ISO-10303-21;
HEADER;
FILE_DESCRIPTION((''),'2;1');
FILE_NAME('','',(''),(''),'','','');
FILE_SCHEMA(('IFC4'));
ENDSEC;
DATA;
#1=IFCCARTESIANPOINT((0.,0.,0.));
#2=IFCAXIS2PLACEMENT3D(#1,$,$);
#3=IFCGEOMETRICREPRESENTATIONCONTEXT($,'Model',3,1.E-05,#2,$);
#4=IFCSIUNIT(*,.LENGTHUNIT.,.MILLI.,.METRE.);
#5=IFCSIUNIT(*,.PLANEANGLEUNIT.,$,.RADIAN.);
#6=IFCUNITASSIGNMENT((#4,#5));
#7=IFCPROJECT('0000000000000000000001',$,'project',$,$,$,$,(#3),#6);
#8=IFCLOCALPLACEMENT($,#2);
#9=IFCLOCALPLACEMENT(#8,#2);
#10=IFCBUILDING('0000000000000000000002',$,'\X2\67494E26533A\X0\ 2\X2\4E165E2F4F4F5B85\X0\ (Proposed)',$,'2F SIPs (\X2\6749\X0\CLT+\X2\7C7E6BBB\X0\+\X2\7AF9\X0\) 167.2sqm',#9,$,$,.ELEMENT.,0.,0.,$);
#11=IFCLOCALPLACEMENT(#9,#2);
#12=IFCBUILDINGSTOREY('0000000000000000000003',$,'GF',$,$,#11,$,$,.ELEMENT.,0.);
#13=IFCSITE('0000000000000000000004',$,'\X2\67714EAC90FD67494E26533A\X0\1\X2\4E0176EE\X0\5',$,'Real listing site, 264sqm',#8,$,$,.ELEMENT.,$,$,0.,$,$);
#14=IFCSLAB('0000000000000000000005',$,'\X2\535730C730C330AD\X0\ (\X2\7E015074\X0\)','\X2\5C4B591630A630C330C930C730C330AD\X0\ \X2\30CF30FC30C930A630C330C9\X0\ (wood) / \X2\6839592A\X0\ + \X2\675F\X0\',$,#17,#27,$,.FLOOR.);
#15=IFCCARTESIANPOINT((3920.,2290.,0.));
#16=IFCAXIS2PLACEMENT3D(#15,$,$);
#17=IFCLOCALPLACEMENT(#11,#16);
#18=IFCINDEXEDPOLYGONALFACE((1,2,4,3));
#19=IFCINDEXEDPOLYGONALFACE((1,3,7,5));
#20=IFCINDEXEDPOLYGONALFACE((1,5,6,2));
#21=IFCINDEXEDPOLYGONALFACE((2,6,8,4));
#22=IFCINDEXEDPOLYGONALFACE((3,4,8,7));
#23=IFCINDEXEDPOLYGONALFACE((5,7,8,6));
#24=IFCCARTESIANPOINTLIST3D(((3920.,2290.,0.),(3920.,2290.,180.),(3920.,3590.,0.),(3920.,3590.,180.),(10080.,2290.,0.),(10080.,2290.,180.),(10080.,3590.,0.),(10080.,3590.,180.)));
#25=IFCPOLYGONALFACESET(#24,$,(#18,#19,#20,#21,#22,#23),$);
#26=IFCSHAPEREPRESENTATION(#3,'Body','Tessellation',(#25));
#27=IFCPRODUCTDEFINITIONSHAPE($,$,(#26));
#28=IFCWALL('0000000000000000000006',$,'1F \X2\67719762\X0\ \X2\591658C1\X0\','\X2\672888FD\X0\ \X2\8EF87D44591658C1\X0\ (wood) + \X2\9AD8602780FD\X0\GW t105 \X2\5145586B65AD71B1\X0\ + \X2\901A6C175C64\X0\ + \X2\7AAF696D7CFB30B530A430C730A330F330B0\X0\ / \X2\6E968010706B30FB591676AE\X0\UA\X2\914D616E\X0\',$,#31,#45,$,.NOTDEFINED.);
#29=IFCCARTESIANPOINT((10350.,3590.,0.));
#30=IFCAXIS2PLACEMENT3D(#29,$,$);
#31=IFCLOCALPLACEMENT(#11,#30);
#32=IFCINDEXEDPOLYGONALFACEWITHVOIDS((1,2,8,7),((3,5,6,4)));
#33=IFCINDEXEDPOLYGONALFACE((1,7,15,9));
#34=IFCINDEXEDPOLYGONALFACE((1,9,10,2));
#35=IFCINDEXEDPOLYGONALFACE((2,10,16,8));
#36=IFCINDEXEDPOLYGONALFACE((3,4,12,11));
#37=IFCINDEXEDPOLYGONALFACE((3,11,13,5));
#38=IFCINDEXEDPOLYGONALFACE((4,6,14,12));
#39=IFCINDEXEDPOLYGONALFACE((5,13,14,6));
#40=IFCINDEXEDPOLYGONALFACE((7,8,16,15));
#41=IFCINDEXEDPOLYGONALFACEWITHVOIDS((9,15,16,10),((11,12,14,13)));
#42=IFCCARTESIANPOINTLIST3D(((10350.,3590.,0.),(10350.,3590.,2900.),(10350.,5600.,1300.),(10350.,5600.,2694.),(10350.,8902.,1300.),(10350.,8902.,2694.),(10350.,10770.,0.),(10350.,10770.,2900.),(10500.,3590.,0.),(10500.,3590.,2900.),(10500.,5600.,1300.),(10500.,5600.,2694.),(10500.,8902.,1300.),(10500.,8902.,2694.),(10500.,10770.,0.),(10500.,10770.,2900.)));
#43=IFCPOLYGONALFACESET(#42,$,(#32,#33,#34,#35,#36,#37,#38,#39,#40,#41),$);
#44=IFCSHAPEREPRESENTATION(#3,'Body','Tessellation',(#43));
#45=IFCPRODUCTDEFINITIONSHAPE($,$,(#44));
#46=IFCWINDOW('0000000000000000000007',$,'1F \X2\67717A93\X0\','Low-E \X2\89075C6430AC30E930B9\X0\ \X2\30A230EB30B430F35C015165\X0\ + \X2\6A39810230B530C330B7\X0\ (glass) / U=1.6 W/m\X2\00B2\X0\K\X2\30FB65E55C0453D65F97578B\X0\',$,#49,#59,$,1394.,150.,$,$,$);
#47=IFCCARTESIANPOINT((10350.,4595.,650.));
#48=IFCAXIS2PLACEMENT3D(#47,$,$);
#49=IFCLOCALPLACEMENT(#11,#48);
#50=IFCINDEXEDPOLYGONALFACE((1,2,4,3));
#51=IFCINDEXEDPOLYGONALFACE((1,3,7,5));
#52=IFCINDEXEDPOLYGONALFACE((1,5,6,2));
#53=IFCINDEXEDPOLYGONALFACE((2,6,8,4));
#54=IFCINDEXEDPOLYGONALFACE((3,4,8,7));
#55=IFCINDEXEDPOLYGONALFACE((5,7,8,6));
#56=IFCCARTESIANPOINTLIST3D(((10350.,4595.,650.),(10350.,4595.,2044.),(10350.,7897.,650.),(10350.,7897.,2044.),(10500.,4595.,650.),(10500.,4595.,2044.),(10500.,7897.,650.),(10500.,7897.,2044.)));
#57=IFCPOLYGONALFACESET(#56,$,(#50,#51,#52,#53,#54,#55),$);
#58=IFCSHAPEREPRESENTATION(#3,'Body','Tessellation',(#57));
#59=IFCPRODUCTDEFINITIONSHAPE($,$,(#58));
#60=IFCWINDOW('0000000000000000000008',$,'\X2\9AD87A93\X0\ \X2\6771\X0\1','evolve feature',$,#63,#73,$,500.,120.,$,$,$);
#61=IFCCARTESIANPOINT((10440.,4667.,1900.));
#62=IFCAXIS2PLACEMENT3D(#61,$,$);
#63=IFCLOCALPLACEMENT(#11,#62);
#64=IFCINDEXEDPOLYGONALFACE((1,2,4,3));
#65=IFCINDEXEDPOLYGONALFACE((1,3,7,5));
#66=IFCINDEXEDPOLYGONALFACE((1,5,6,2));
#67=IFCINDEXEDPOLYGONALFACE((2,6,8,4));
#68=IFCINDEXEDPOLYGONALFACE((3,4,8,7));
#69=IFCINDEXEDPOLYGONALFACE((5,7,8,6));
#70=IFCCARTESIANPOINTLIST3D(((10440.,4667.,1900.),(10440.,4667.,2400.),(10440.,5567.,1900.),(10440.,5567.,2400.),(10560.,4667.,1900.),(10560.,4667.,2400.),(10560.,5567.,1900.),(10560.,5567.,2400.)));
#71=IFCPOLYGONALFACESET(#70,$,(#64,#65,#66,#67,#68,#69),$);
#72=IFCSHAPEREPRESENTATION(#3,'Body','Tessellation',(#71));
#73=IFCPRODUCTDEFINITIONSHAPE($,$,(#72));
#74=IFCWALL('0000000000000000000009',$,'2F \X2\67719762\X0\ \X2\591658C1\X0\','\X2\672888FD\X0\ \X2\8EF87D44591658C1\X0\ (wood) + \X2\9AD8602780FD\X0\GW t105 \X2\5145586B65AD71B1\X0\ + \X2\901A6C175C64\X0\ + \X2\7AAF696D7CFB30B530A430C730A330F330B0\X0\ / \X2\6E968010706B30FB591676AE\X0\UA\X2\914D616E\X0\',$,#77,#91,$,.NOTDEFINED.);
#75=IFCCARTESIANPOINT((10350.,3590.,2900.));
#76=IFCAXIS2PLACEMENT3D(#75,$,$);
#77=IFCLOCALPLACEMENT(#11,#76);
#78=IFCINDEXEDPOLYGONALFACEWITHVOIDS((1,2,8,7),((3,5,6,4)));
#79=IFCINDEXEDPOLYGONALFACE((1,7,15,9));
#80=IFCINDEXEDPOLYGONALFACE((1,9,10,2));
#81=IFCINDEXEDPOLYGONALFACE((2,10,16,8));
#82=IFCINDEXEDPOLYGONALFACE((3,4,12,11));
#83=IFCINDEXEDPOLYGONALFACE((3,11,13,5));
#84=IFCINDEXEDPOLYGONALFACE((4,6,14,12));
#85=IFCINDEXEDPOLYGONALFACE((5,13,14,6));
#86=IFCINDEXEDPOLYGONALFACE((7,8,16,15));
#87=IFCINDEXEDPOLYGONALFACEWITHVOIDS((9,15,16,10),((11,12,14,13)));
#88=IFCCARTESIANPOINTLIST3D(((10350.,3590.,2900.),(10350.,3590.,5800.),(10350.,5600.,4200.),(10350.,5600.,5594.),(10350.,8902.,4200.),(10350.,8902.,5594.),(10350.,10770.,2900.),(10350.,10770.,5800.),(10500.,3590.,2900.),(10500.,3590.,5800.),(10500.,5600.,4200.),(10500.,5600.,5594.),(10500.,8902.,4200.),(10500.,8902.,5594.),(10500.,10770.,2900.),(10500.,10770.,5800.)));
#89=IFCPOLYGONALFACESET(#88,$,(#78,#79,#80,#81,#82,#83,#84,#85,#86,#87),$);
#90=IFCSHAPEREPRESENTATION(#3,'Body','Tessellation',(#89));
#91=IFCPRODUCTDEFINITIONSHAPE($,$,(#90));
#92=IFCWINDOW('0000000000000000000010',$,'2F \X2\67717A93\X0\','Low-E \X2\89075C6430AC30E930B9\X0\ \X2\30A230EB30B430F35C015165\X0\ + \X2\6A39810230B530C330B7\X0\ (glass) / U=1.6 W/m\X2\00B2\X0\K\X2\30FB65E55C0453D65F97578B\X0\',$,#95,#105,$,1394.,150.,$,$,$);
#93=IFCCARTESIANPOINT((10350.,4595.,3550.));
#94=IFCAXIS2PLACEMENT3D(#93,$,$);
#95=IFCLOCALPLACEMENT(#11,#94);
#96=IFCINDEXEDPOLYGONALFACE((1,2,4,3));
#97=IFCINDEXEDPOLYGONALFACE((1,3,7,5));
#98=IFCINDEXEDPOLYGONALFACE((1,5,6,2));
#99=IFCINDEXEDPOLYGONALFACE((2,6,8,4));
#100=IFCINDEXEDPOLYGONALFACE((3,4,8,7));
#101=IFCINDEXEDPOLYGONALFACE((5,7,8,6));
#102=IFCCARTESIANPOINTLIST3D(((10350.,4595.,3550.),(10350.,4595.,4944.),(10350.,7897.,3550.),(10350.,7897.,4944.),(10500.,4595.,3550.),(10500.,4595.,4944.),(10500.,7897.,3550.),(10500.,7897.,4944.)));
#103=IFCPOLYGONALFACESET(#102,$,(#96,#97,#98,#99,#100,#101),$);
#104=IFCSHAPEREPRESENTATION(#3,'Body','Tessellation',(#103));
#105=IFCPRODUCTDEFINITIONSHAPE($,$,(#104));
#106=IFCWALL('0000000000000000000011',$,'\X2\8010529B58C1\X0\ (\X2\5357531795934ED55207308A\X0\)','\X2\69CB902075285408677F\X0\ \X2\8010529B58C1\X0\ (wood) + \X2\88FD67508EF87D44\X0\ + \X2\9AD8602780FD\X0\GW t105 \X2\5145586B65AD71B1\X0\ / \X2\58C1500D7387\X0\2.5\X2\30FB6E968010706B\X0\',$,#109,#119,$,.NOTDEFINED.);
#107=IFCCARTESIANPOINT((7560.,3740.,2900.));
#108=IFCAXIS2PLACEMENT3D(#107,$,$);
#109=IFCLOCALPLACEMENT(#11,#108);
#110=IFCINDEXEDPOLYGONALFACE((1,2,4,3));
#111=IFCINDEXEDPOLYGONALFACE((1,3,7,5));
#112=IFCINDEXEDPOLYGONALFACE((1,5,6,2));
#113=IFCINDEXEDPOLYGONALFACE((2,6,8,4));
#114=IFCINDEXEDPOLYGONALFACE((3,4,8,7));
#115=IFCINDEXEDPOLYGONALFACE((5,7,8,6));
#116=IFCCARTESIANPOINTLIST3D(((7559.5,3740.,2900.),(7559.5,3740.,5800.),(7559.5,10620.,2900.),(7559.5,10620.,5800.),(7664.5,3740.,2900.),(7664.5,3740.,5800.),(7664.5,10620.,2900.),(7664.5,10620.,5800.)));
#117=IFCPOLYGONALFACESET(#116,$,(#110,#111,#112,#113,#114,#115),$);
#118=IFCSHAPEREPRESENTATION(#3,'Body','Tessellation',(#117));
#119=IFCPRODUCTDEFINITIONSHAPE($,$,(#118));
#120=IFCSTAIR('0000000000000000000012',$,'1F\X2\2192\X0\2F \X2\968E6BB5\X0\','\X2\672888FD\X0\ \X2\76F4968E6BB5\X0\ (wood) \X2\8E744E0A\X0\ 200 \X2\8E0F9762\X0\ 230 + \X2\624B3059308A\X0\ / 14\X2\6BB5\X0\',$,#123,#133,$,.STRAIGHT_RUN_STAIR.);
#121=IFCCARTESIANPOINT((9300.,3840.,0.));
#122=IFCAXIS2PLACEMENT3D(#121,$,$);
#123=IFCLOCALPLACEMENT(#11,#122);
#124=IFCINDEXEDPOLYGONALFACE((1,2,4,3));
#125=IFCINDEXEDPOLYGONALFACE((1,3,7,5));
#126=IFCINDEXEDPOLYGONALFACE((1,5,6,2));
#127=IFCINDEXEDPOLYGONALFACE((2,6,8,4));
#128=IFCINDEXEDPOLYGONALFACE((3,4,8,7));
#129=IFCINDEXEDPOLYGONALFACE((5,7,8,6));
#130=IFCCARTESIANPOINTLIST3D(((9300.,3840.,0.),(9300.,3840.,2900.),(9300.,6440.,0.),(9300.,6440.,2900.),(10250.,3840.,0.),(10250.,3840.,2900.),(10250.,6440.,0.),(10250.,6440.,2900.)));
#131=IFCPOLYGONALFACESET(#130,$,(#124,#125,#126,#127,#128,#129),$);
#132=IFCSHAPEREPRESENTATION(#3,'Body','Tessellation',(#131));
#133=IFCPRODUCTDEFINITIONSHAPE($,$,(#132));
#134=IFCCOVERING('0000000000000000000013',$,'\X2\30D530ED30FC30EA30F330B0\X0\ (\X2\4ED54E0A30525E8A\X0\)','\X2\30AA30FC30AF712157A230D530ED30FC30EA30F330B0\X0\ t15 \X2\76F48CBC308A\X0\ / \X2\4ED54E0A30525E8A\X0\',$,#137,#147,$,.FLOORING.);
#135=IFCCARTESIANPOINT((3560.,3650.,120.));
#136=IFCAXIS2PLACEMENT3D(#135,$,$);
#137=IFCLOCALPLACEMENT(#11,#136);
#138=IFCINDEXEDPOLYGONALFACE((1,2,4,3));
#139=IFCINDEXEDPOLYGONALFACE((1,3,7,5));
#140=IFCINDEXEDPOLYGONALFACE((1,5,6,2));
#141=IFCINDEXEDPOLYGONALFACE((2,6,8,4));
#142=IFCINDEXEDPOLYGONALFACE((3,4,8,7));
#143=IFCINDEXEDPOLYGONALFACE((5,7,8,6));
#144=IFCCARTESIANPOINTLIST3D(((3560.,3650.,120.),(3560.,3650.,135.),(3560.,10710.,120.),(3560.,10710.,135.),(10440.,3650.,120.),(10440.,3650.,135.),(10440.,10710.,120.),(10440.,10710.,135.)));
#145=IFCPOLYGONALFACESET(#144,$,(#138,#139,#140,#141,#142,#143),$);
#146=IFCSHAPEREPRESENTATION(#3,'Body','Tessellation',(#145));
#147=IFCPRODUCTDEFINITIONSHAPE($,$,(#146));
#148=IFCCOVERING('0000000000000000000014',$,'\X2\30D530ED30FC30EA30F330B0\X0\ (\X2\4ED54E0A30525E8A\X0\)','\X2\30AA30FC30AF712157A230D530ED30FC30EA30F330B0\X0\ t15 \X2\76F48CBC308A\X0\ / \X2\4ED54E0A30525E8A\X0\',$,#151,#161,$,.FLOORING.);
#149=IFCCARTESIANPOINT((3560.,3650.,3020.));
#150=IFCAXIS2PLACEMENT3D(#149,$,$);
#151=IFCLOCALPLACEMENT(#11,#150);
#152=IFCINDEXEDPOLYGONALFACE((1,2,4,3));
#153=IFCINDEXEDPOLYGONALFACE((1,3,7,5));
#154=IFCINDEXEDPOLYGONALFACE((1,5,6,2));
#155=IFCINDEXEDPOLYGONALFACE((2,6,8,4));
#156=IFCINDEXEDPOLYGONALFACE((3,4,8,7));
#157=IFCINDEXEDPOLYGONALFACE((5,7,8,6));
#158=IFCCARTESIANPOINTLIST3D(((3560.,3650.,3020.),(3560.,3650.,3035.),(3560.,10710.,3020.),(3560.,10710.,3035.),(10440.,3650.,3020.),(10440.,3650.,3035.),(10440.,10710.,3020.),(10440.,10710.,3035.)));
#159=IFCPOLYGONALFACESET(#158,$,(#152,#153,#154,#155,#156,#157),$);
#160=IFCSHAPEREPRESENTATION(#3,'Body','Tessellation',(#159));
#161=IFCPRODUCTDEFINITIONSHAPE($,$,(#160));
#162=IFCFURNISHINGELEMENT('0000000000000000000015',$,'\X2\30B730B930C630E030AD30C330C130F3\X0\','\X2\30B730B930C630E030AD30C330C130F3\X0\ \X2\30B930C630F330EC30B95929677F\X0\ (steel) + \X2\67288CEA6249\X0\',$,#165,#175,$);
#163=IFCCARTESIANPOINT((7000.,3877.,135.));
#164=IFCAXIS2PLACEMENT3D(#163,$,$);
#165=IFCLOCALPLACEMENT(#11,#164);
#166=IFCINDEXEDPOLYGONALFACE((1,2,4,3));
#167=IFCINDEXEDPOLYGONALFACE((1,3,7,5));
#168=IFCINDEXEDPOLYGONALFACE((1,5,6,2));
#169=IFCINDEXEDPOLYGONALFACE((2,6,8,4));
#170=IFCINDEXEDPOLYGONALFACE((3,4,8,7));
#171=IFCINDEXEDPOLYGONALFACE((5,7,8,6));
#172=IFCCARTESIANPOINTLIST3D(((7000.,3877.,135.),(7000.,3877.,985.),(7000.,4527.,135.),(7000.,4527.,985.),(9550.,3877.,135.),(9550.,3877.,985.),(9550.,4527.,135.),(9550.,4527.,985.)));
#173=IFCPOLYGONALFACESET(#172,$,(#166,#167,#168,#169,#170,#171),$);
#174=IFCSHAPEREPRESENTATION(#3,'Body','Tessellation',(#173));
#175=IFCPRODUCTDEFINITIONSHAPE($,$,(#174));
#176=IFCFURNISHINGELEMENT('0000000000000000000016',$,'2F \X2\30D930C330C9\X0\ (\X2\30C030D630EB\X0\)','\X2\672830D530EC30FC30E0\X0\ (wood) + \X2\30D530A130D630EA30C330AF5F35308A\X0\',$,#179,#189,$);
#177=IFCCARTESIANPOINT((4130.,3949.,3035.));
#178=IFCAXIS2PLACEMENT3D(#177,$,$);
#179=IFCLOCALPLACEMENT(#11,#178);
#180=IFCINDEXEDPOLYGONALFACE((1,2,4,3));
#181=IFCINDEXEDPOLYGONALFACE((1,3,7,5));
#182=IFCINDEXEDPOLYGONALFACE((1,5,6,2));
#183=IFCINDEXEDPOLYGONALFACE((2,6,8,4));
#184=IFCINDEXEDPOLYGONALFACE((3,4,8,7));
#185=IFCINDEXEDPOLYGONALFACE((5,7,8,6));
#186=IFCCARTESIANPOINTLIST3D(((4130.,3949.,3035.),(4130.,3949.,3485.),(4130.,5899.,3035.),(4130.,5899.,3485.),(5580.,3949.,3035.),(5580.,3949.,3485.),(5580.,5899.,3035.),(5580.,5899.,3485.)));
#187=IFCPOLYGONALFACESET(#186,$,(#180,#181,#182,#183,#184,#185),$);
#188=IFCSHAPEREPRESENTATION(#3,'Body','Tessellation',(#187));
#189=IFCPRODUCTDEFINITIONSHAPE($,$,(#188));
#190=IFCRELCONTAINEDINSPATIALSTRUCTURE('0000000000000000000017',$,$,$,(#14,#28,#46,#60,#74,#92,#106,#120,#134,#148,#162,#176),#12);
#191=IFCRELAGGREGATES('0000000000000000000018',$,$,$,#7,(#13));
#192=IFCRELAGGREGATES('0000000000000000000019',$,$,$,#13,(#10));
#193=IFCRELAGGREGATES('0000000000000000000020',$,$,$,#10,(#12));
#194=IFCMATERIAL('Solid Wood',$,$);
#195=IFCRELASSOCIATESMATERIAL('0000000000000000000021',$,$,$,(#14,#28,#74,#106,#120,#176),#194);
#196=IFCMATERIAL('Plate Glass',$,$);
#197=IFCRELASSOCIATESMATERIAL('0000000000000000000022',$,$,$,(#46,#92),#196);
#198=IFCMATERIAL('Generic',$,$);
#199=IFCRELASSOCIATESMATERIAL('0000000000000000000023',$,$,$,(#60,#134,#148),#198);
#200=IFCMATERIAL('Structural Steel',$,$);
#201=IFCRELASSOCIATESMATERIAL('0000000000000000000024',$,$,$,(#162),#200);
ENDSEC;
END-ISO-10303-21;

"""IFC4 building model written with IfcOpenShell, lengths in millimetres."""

from ifc_helpers import new_model, si_unit, frame, frame_2d, origin, place, context, project, spatial, rectangle, extrude, material, element, fill, save


model = new_model("IFC4")

# Units and contexts
model_context = context("Model", 3, precision=1e-05, world=origin())
ifc_project = project(units=[si_unit("LENGTHUNIT", "METRE", prefix="MILLI"), si_unit("PLANEANGLEUNIT", "RADIAN")], contexts=[model_context])

# Site, building, storey
site_placement = place(None, origin())
site = spatial("IfcSite", under=ifc_project, at=site_placement, Name="東京都杉並区1丁目5", ObjectType="Real listing site, 264sqm", CompositionType="ELEMENT", RefElevation=0.0)
building_placement = place(site_placement, origin())
building = spatial("IfcBuilding", under=site, at=building_placement, Name="杉並区 2世帯住宅 (Proposed)", ObjectType="2F SIPs (杉CLT+籾殻+竹) 167.2sqm", CompositionType="ELEMENT", ElevationOfRefHeight=0.0, ElevationOfTerrain=0.0)
storey_placement = place(building_placement, origin())
storey = spatial("IfcBuildingStorey", under=building, at=storey_placement, Name="GF", CompositionType="ELEMENT", Elevation=0.0)

# Slab
ifc_material_1 = material(Name="Solid Wood")
slab_placement = place(storey_placement, frame((3920.0, 2290.0, 0.0)))
element("IfcSlab", 1, at=slab_placement, inside=storey, material=ifc_material_1, Name="南デッキ (縁側)", Description="屋外ウッドデッキ ハードウッド (wood) / 根太 + 束", PredefinedType="FLOOR", context=model_context, shape_type="SweptSolid", body=[
    extrude(rectangle(XDim=6160.0, YDim=1300.0, at=frame_2d((3080.0, 650.0))), frame((3920.0, 2290.0, 0.0)), (0.0, 0.0, 1.0), 180.0),
])

# Wall, openings, windows
wall_1_placement = place(storey_placement, frame((10350.0, 3590.0, 0.0)))
wall_1 = element("IfcWall", 2, at=wall_1_placement, inside=storey, material=ifc_material_1, Name="1F 東面 外壁", Description="木製 軸組外壁 (wood) + 高性能GW t105 充填断熱 + 通気層 + 窯業系サイディング / 準耐火・外皮UA配慮", PredefinedType="NOTDEFINED", context=model_context, shape_type="SweptSolid", body=[
    extrude(rectangle(XDim=150.0, YDim=7180.0, at=frame_2d((75.0, 3590.0))), frame((10350.0, 3590.0, 0.0)), (0.0, 0.0, 1.0), 2900.0),
])
opening_1_placement = place(storey_placement, frame((10350.0, 4595.0, 650.0)))
opening_1 = element("IfcOpeningElement", 3, at=opening_1_placement, cuts=wall_1, PredefinedType="NOTDEFINED", context=model_context, shape_type="SweptSolid", body=[
    extrude(rectangle(XDim=150.0, YDim=3302.0, at=frame_2d((75.0, 1651.0))), frame((10350.0, 4595.0, 650.0)), (0.0, 0.0, 1.0), 1394.0),
])
opening_2_placement = place(storey_placement, frame((10440.0, 4667.0, 1900.0)))
opening_2 = element("IfcOpeningElement", 4, at=opening_2_placement, cuts=wall_1, PredefinedType="NOTDEFINED", context=model_context, shape_type="SweptSolid", body=[
    extrude(rectangle(XDim=120.0, YDim=900.0, at=frame_2d((60.0, 450.0))), frame((10440.0, 4667.0, 1900.0)), (0.0, 0.0, 1.0), 500.0),
])
ifc_material_2 = material(Name="Plate Glass")
window_1_placement = place(storey_placement, frame((10350.0, 4595.0, 650.0)))
window_1 = element("IfcWindow", 5, at=window_1_placement, inside=storey, material=ifc_material_2, Name="1F 東窓", Description="Low-E 複層ガラス アルゴン封入 + 樹脂サッシ (glass) / U=1.6 W/m²K・日射取得型", OverallHeight=1394.0, OverallWidth=150.0, context=model_context, shape_type="SweptSolid", body=[
    extrude(rectangle(XDim=150.0, YDim=3302.0, at=frame_2d((75.0, 1651.0))), frame((10350.0, 4595.0, 650.0)), (0.0, 0.0, 1.0), 1394.0),
])
fill(opening_1, window_1)
ifc_material_3 = material(Name="Generic")
window_2_placement = place(storey_placement, frame((10440.0, 4667.0, 1900.0)))
window_2 = element("IfcWindow", 6, at=window_2_placement, inside=storey, material=ifc_material_3, Name="高窓 東1", Description="evolve feature", OverallHeight=500.0, OverallWidth=120.0, context=model_context, shape_type="SweptSolid", body=[
    extrude(rectangle(XDim=120.0, YDim=900.0, at=frame_2d((60.0, 450.0))), frame((10440.0, 4667.0, 1900.0)), (0.0, 0.0, 1.0), 500.0),
])
fill(opening_2, window_2)

# Wall, opening, window
wall_2_placement = place(storey_placement, frame((10350.0, 3590.0, 2900.0)))
wall_2 = element("IfcWall", 7, at=wall_2_placement, inside=storey, material=ifc_material_1, Name="2F 東面 外壁", Description="木製 軸組外壁 (wood) + 高性能GW t105 充填断熱 + 通気層 + 窯業系サイディング / 準耐火・外皮UA配慮", PredefinedType="NOTDEFINED", context=model_context, shape_type="SweptSolid", body=[
    extrude(rectangle(XDim=150.0, YDim=7180.0, at=frame_2d((75.0, 3590.0))), frame((10350.0, 3590.0, 2900.0)), (0.0, 0.0, 1.0), 2900.0),
])
opening_3_placement = place(storey_placement, frame((10350.0, 4595.0, 3550.0)))
opening_3 = element("IfcOpeningElement", 8, at=opening_3_placement, cuts=wall_2, PredefinedType="NOTDEFINED", context=model_context, shape_type="SweptSolid", body=[
    extrude(rectangle(XDim=150.0, YDim=3302.0, at=frame_2d((75.0, 1651.0))), frame((10350.0, 4595.0, 3550.0)), (0.0, 0.0, 1.0), 1394.0),
])
window_3_placement = place(storey_placement, frame((10350.0, 4595.0, 3550.0)))
window_3 = element("IfcWindow", 9, at=window_3_placement, inside=storey, material=ifc_material_2, Name="2F 東窓", Description="Low-E 複層ガラス アルゴン封入 + 樹脂サッシ (glass) / U=1.6 W/m²K・日射取得型", OverallHeight=1394.0, OverallWidth=150.0, context=model_context, shape_type="SweptSolid", body=[
    extrude(rectangle(XDim=150.0, YDim=3302.0, at=frame_2d((75.0, 1651.0))), frame((10350.0, 4595.0, 3550.0)), (0.0, 0.0, 1.0), 1394.0),
])
fill(opening_3, window_3)

# Wall
wall_3_placement = place(storey_placement, frame((7560.0, 3740.0, 2900.0)))
element("IfcWall", 10, at=wall_3_placement, inside=storey, material=ifc_material_1, Name="耐力壁 (南北間仕切り)", Description="構造用合板 耐力壁 (wood) + 製材軸組 + 高性能GW t105 充填断熱 / 壁倍率2.5・準耐火", PredefinedType="NOTDEFINED", context=model_context, shape_type="SweptSolid", body=[
    extrude(rectangle(XDim=105.0, YDim=6880.0, at=frame_2d((52.0, 3440.0))), frame((7560.0, 3740.0, 2900.0)), (0.0, 0.0, 1.0), 2900.0),
])

# Stair
stair_placement = place(storey_placement, frame((9300.0, 3840.0, 0.0)))
element("IfcStair", 11, at=stair_placement, inside=storey, material=ifc_material_1, Name="1F→2F 階段", Description="木製 直階段 (wood) 蹴上 200 踏面 230 + 手すり / 14段", PredefinedType="STRAIGHT_RUN_STAIR", context=model_context, shape_type="SweptSolid", body=[
    extrude(rectangle(XDim=950.0, YDim=2600.0, at=frame_2d((475.0, 1300.0))), frame((9300.0, 3840.0, 0.0)), (0.0, 0.0, 1.0), 2900.0),
])

# Coverings
covering_1_placement = place(storey_placement, frame((3560.0, 3650.0, 120.0)))
element("IfcCovering", 12, at=covering_1_placement, inside=storey, material=ifc_material_3, Name="フローリング (仕上げ床)", Description="オーク無垢フローリング t15 直貼り / 仕上げ床", PredefinedType="FLOORING", context=model_context, shape_type="SweptSolid", body=[
    extrude(rectangle(XDim=6880.0, YDim=7060.0, at=frame_2d((3440.0, 3530.0))), frame((3560.0, 3650.0, 120.0)), (0.0, 0.0, 1.0), 15.0),
])
covering_2_placement = place(storey_placement, frame((3560.0, 3650.0, 3020.0)))
element("IfcCovering", 13, at=covering_2_placement, inside=storey, material=ifc_material_3, Name="フローリング (仕上げ床)", Description="オーク無垢フローリング t15 直貼り / 仕上げ床", PredefinedType="FLOORING", context=model_context, shape_type="SweptSolid", body=[
    extrude(rectangle(XDim=6880.0, YDim=7060.0, at=frame_2d((3440.0, 3530.0))), frame((3560.0, 3650.0, 3020.0)), (0.0, 0.0, 1.0), 15.0),
])

# Furnishing elements
ifc_material_4 = material(Name="Structural Steel")
furnishing_1_placement = place(storey_placement, frame((7000.0, 3877.0, 135.0)))
element("IfcFurnishingElement", 14, at=furnishing_1_placement, inside=storey, material=ifc_material_4, Name="システムキッチン", Description="システムキッチン ステンレス天板 (steel) + 木質扉", context=model_context, shape_type="SweptSolid", body=[
    extrude(rectangle(XDim=2550.0, YDim=650.0, at=frame_2d((1275.0, 325.0))), frame((7000.0, 3877.0, 135.0)), (0.0, 0.0, 1.0), 850.0),
])
furnishing_2_placement = place(storey_placement, frame((4130.0, 3949.0, 3035.0)))
element("IfcFurnishingElement", 15, at=furnishing_2_placement, inside=storey, material=ifc_material_1, Name="2F ベッド (ダブル)", Description="木フレーム (wood) + ファブリック張り", context=model_context, shape_type="SweptSolid", body=[
    extrude(rectangle(XDim=1450.0, YDim=1950.0, at=frame_2d((725.0, 975.0))), frame((4130.0, 3949.0, 3035.0)), (0.0, 0.0, 1.0), 450.0),
])

save(model, "model.ifc")
